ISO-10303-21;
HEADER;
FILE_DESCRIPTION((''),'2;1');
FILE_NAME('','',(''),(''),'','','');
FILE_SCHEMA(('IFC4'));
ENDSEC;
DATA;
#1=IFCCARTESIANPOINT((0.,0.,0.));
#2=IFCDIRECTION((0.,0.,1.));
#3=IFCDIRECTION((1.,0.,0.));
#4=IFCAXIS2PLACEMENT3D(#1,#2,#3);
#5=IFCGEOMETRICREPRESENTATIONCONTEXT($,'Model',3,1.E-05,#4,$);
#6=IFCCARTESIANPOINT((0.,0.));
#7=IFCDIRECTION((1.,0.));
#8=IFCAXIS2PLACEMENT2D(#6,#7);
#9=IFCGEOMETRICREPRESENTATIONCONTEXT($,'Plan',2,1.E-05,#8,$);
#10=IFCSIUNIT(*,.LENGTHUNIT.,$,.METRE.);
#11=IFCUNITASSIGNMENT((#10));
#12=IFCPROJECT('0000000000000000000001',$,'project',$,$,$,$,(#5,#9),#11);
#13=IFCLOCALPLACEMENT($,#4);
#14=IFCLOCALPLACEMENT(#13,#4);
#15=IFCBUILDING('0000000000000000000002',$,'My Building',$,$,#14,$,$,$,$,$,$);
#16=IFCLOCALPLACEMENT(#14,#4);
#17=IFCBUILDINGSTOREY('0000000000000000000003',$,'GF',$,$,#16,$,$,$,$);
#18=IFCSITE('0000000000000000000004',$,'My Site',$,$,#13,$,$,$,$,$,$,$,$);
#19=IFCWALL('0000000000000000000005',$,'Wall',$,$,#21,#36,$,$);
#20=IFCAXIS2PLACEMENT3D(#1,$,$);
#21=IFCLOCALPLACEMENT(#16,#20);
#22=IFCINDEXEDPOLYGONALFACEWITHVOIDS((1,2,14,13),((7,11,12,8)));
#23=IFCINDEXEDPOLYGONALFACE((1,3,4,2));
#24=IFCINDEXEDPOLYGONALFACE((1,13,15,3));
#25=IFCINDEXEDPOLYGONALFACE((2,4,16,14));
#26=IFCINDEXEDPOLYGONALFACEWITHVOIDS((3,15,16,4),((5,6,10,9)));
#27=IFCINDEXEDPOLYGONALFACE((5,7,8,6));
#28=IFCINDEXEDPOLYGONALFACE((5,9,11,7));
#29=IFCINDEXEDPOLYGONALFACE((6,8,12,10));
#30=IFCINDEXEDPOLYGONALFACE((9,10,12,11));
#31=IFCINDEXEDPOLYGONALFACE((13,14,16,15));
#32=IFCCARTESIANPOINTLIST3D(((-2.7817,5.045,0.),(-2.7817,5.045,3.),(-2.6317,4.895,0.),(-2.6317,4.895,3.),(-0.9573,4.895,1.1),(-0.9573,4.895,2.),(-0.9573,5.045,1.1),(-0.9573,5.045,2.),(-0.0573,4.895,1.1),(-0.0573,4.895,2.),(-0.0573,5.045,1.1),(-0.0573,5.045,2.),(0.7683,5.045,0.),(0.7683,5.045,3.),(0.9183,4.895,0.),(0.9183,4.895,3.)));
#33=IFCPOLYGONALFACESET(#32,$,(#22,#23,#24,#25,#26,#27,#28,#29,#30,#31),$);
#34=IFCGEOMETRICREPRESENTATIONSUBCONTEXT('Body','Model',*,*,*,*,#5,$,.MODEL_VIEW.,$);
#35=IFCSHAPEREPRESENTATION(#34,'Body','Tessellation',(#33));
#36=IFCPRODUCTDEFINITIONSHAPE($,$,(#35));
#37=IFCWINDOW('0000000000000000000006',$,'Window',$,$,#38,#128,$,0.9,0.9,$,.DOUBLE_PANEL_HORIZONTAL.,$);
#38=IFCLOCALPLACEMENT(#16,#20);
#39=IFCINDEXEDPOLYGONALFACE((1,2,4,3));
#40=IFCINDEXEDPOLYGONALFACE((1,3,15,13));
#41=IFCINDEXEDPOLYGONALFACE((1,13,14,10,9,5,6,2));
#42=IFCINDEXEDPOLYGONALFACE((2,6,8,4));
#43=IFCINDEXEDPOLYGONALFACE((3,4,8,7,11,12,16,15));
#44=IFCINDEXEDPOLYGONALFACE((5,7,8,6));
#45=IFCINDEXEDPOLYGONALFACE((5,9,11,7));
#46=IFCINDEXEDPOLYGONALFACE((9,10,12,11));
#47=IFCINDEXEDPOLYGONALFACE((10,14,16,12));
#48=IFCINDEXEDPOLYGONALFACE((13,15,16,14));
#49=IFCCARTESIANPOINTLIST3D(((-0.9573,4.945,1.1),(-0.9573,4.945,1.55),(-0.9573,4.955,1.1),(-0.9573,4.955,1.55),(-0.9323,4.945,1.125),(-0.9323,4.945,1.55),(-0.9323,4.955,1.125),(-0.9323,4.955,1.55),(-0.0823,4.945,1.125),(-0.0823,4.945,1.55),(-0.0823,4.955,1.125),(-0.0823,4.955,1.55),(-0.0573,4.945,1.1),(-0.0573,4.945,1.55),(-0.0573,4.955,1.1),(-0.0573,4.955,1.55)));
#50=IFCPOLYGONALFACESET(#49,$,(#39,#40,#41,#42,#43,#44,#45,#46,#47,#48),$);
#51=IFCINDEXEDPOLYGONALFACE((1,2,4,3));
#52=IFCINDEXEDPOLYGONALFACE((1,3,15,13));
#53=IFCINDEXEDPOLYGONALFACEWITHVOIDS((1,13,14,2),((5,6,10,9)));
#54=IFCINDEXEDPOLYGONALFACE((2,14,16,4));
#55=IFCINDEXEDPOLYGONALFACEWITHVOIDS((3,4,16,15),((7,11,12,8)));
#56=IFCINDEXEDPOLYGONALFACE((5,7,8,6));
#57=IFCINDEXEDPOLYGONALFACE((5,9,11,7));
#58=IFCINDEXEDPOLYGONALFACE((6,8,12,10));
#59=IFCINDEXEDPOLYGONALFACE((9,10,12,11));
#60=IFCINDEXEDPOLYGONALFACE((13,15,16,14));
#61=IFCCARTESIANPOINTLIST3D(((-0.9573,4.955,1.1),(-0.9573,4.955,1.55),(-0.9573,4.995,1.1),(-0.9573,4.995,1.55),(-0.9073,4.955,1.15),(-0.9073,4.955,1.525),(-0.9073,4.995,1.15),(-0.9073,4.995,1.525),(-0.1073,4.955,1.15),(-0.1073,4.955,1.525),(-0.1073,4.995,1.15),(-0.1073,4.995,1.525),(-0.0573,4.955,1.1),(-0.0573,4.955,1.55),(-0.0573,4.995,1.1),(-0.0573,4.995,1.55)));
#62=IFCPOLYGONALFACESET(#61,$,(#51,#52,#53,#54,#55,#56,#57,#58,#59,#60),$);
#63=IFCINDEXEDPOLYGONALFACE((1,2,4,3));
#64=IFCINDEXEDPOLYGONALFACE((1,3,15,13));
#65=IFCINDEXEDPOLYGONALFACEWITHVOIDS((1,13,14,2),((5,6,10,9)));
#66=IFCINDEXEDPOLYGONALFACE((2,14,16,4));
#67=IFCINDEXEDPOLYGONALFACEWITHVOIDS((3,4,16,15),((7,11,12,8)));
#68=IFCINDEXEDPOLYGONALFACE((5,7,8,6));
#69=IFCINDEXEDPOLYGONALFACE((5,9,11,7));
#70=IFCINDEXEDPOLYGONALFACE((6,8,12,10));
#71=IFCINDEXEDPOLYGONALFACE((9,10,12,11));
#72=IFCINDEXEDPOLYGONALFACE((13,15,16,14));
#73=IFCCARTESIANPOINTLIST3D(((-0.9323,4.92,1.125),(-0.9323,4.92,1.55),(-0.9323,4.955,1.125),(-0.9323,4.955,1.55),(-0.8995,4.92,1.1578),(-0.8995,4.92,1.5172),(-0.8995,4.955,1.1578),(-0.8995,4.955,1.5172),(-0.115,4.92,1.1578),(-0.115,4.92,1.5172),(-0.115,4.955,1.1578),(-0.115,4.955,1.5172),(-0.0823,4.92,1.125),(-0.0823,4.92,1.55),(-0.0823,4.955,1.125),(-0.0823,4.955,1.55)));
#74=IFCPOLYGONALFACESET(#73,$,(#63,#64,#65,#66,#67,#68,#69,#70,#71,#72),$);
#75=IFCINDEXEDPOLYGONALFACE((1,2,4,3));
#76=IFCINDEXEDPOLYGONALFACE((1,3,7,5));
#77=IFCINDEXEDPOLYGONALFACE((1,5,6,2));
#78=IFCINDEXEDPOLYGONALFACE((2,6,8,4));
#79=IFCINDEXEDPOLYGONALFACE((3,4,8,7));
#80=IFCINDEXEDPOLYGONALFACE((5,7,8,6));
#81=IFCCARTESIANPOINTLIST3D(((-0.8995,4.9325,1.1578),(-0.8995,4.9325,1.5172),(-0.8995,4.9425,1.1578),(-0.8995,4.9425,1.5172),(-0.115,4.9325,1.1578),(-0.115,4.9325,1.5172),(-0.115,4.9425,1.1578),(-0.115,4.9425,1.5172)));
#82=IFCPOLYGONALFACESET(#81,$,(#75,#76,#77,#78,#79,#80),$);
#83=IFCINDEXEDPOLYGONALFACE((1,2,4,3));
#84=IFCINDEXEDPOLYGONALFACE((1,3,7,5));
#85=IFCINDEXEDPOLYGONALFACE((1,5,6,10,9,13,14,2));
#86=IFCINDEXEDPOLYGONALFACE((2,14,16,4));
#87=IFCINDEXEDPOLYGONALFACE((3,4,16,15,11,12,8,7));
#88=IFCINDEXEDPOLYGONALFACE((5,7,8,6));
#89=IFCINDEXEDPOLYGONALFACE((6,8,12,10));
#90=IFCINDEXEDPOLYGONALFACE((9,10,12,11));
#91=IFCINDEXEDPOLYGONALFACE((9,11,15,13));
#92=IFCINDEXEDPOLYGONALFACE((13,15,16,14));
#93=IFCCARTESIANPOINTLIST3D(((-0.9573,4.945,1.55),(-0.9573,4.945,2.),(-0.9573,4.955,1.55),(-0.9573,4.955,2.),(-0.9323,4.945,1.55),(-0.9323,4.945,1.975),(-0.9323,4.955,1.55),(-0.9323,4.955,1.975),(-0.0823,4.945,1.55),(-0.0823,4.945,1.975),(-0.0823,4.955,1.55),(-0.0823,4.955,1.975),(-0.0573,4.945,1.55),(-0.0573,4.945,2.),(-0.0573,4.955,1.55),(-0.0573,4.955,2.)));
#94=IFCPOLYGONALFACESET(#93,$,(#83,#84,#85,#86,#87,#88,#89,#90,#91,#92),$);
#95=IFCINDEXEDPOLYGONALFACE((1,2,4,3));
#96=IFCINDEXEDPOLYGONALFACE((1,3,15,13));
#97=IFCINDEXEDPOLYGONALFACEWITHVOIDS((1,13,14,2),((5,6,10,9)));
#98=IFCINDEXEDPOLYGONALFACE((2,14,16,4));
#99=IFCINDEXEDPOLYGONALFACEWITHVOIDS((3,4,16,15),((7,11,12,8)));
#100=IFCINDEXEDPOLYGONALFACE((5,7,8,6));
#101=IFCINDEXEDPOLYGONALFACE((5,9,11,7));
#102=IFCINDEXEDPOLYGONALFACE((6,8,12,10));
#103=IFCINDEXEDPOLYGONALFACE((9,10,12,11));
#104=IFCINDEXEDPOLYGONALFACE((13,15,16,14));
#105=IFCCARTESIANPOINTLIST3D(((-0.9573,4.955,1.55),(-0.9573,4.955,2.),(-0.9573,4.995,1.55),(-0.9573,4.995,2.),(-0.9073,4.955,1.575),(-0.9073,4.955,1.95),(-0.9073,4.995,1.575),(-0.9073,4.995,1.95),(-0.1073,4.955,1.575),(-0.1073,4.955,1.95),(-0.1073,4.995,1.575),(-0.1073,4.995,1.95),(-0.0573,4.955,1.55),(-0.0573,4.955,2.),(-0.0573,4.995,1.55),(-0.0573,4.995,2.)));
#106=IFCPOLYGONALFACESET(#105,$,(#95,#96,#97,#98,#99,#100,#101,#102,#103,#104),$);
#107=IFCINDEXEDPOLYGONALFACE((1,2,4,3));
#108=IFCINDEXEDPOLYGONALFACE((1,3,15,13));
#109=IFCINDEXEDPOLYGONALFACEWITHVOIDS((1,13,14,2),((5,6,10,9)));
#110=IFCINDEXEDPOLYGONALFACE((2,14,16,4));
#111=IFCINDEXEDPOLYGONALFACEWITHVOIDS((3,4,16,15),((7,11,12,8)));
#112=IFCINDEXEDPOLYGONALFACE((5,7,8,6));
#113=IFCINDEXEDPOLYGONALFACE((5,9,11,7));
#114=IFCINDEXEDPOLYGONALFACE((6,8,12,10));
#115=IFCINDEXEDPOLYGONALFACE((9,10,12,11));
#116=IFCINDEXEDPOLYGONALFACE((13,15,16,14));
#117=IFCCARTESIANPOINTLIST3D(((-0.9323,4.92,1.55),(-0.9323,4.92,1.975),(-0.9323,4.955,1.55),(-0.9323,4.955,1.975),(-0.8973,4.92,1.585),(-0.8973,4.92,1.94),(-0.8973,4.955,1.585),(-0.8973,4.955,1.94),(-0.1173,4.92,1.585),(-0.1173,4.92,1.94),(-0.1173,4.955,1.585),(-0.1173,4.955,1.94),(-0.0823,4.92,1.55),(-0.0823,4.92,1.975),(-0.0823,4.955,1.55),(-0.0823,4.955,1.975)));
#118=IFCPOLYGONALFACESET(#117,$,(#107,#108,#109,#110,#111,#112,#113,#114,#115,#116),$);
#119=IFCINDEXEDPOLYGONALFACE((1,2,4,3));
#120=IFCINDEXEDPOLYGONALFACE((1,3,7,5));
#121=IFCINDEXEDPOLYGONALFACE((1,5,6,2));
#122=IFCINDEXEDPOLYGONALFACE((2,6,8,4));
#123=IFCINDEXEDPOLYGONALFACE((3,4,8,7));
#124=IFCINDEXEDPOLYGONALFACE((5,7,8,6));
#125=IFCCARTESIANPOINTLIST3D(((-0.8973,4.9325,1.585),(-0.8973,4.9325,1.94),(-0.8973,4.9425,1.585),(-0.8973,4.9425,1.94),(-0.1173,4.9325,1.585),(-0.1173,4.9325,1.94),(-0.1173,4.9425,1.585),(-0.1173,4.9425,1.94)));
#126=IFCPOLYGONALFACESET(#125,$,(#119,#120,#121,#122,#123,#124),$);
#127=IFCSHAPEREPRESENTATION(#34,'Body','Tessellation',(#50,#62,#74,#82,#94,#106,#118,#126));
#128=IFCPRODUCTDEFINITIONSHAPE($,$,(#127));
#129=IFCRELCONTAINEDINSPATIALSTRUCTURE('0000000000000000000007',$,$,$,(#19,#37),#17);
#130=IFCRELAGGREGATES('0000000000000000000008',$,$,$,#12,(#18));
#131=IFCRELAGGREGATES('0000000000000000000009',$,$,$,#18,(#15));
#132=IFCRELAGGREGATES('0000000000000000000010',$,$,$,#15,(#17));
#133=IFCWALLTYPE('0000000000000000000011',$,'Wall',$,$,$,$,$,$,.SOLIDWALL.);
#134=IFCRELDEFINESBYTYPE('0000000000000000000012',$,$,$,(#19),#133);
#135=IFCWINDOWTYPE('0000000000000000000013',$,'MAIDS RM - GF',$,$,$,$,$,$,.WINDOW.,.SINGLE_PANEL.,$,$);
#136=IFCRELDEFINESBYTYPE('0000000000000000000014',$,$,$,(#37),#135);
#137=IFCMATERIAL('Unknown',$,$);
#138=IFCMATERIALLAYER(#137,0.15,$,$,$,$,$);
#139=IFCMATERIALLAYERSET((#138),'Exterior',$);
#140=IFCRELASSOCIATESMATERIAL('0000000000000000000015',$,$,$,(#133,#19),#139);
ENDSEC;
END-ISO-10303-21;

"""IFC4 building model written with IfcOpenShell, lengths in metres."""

from ifc_helpers import new_model, entity, si_unit, frame, origin_with_axes, origin_2d_with_axis, place, context, subcontext, project, spatial, line, indexed_curve, outline, extrude, shape, source, transform, mapped, material, layer, layer_set, layer_usage, type_object, type_shapes, element, fill, save


model = new_model("IFC4")

# Units and contexts
model_context = context("Model", 3, precision=1e-05, world=origin_with_axes())
plan_context = context("Plan", 2, precision=1e-05, world=origin_2d_with_axis())
body_context_1 = subcontext(model_context, "Body", "Model", "MODEL_VIEW")
body_context_2 = subcontext(plan_context, "Body", "Plan", "PLAN_VIEW")
ifc_project = project(units=[si_unit("LENGTHUNIT", "METRE")], contexts=[model_context, plan_context])

# Site, building, storey
site_placement = place(None, origin_with_axes())
site = spatial("IfcSite", under=ifc_project, at=site_placement, Name="My Site")
building_placement = place(site_placement, origin_with_axes())
building = spatial("IfcBuilding", under=site, at=building_placement, Name="My Building")
storey_placement = place(building_placement, origin_with_axes())
storey = spatial("IfcBuildingStorey", under=building, at=storey_placement, Name="GF")

# Shared definitions
ifc_material = material(Name="Unknown")
ifc_layer_1 = layer(ifc_material, 0.15)
ifc_layer_set_1 = layer_set([ifc_layer_1], Name="Exterior")
wall_type_1 = type_object("IfcWallType", Name="Wall", PredefinedType="SOLIDWALL", material=ifc_layer_set_1)

# Wall, opening, window
ifc_layer_usage_1 = layer_usage(ifc_layer_set_1, "AXIS2", "POSITIVE", 0.0)
wall_1_placement = place(storey_placement, frame((0.7683, 5.045, 0.0), z_axis=(0.0, 0.0, 1.0), x_axis=(-1.0, 0.0, 0.0)))
wall_1 = element("IfcWall", 1, at=wall_1_placement, inside=storey, type_object=wall_type_1, material=ifc_layer_usage_1, Name="Wall", context=body_context_1, shape_type="SweptSolid", body=[
    extrude(outline(indexed_curve([(0.0, 0.0), (-0.15, 0.15), (3.4, 0.15), (3.55, 0.0)], segments=[line(1, 2, 3, 4, 1)])), origin_with_axes(), (0.0, 0.0, 1.0), 3.0),
])
shared_shape_1 = source(origin_with_axes(), body_context_1, "Body", "SweptSolid", [
    extrude(outline(indexed_curve([(0.0, 0.0), (0.9, 0.0), (0.9, 0.9), (0.0, 0.9)], segments=[line(1, 2, 3, 4, 1)])), frame((0.0, -0.6, 0.0), z_axis=(0.0, -1.0, 0.0), x_axis=(1.0, 0.0, 0.0)), (0.0, 0.0, -1.0), 1.2),
])
opening_1_placement = place(wall_1_placement, frame((0.8256, 0.0, 1.1), z_axis=(0.0, 0.0, 1.0), x_axis=(1.0, 0.0, 0.0)))
opening_1 = element("IfcOpeningElement", 2, at=opening_1_placement, cuts=wall_1, PredefinedType="OPENING", context=body_context_1, shape_type="MappedRepresentation", body=[
    mapped(shared_shape_1, transform((0.0, 0.0, 0.0), x_axis=(1.0, 0.0, 0.0), y_axis=(0.0, 1.0, 0.0), z_axis=(0.0, 0.0, 1.0), scale=1.0)),
])
window_type_1 = type_object("IfcWindowType", Name="MAIDS RM - GF", PartitioningType="SINGLE_PANEL", PredefinedType="WINDOW")
shared_shape_2 = source(origin_with_axes(), body_context_1, "Body", "SweptSolid", [
    extrude(outline(indexed_curve([(0.9, 0.45), (0.9, 0.0), (0.0, 0.0), (0.0, 0.45), (0.025, 0.45), (0.025, 0.025), (0.875, 0.025), (0.875, 0.45)], segments=[line(1, 2, 3, 4, 5, 6, 7, 8, 1)])), frame((0.0, 0.09, 0.0), z_axis=(0.0, -1.0, 0.0), x_axis=(1.0, 0.0, 0.0)), (0.0, 0.0, -1.0), 0.01),
    extrude(outline(indexed_curve([(0.0, 0.0), (0.9, 0.0), (0.9, 0.45), (0.0, 0.45)], segments=[line(1, 2, 3, 4, 1)]), holes=[indexed_curve([(0.05, 0.05), (0.85, 0.05), (0.85, 0.425), (0.05, 0.425)], segments=[line(1, 2, 3, 4, 1)])]), frame((0.0, 0.05, 0.0), z_axis=(0.0, -1.0, 0.0), x_axis=(1.0, 0.0, 0.0)), (0.0, 0.0, -1.0), 0.04),
    extrude(outline(indexed_curve([(0.0, 0.0), (0.85, 0.0), (0.85, 0.425), (0.0, 0.425)], segments=[line(1, 2, 3, 4, 1)]), holes=[indexed_curve([(0.0328, 0.0328), (0.8172, 0.0328), (0.8172, 0.3922), (0.0328, 0.3922)], segments=[line(1, 2, 3, 4, 1)])]), frame((0.025, 0.09, 0.025), z_axis=(0.0, -1.0, 0.0), x_axis=(1.0, 0.0, 0.0)), (0.0, 0.0, -1.0), 0.035),
    extrude(outline(indexed_curve([(0.0328, 0.0328), (0.8172, 0.0328), (0.8172, 0.3922), (0.0328, 0.3922)], segments=[line(1, 2, 3, 4, 1)])), frame((0.025, 0.1025, 0.025), z_axis=(0.0, -1.0, 0.0), x_axis=(1.0, 0.0, 0.0)), (0.0, 0.0, -1.0), 0.01),
    extrude(outline(indexed_curve([(0.0, 0.0), (0.0, 0.45), (0.9, 0.45), (0.9, 0.0), (0.875, 0.0), (0.875, 0.425), (0.025, 0.425), (0.025, 0.0)], segments=[line(1, 2, 3, 4, 5, 6, 7, 8, 1)])), frame((0.0, 0.09, 0.45), z_axis=(0.0, -1.0, 0.0), x_axis=(1.0, 0.0, 0.0)), (0.0, 0.0, -1.0), 0.01),
    extrude(outline(indexed_curve([(0.0, 0.0), (0.9, 0.0), (0.9, 0.45), (0.0, 0.45)], segments=[line(1, 2, 3, 4, 1)]), holes=[indexed_curve([(0.05, 0.025), (0.85, 0.025), (0.85, 0.4), (0.05, 0.4)], segments=[line(1, 2, 3, 4, 1)])]), frame((0.0, 0.05, 0.45), z_axis=(0.0, -1.0, 0.0), x_axis=(1.0, 0.0, 0.0)), (0.0, 0.0, -1.0), 0.04),
    extrude(outline(indexed_curve([(0.0, 0.0), (0.85, 0.0), (0.85, 0.425), (0.0, 0.425)], segments=[line(1, 2, 3, 4, 1)]), holes=[indexed_curve([(0.035, 0.035), (0.815, 0.035), (0.815, 0.39), (0.035, 0.39)], segments=[line(1, 2, 3, 4, 1)])]), frame((0.025, 0.09, 0.45), z_axis=(0.0, -1.0, 0.0), x_axis=(1.0, 0.0, 0.0)), (0.0, 0.0, -1.0), 0.035),
    extrude(outline(indexed_curve([(0.035, 0.035), (0.815, 0.035), (0.815, 0.39), (0.035, 0.39)], segments=[line(1, 2, 3, 4, 1)])), frame((0.025, 0.1025, 0.45), z_axis=(0.0, -1.0, 0.0), x_axis=(1.0, 0.0, 0.0)), (0.0, 0.0, -1.0), 0.01),
])
shared_shape_3 = source(origin_with_axes(), body_context_2, "Body", "Curve2D", [
    entity("IfcIndexedPolyCurve", entity("IfcCartesianPointList2D", [[0.05, 0.05], [0.85, 0.05]])),
    entity("IfcIndexedPolyCurve", entity("IfcCartesianPointList2D", [[0.0, 0.1], [0.025, 0.1], [0.025, 0.09], [0.05, 0.09], [0.05, 0.05], [0.0, 0.05]]), [entity("IfcLineIndex", [1, 2, 3, 4, 5, 6, 1])]),
    entity("IfcIndexedPolyCurve", entity("IfcCartesianPointList2D", [[0.9, 0.1], [0.875, 0.1], [0.875, 0.09], [0.85, 0.09], [0.85, 0.05], [0.9, 0.05]]), [entity("IfcLineIndex", [1, 2, 3, 4, 5, 6, 1])]),
    entity("IfcIndexedPolyCurve", entity("IfcCartesianPointList2D", [[0.025, 0.09], [0.06, 0.09], [0.06, 0.125], [0.025, 0.125]]), [entity("IfcLineIndex", [1, 2, 3, 4, 1])]),
    entity("IfcIndexedPolyCurve", entity("IfcCartesianPointList2D", [[0.875, 0.09], [0.84, 0.09], [0.84, 0.125], [0.875, 0.125]]), [entity("IfcLineIndex", [1, 2, 3, 4, 1])]),
    entity("IfcIndexedPolyCurve", entity("IfcCartesianPointList2D", [[0.06, 0.09], [0.84, 0.09]])),
    entity("IfcIndexedPolyCurve", entity("IfcCartesianPointList2D", [[0.06, 0.125], [0.84, 0.125]])),
    entity("IfcIndexedPolyCurve", entity("IfcCartesianPointList2D", [[0.06, 0.1075], [0.84, 0.1075]])),
])
type_shapes(window_type_1, [shared_shape_2, shared_shape_3])
window_1_placement = place(opening_1_placement, frame((0.0, 0.0, 0.0), z_axis=(0.0, 0.0, 1.0), x_axis=(1.0, 0.0, 0.0)))
window_1 = element("IfcWindow", 3, at=window_1_placement, inside=storey, type_object=window_type_1, Name="Window", OverallHeight=0.9, OverallWidth=0.9, PartitioningType="DOUBLE_PANEL_HORIZONTAL", shapes=[
    shape(body_context_1, "Body", "MappedRepresentation", [mapped(shared_shape_2, transform((0.0, 0.0, 0.0), x_axis=(1.0, 0.0, 0.0), y_axis=(0.0, 1.0, 0.0), z_axis=(0.0, 0.0, 1.0), scale=1.0))]),
    shape(body_context_2, "Body", "MappedRepresentation", [mapped(shared_shape_3, transform((0.0, 0.0, 0.0), x_axis=(1.0, 0.0, 0.0), y_axis=(0.0, 1.0, 0.0), z_axis=(0.0, 0.0, 1.0), scale=1.0))]),
])
fill(opening_1, window_1)

save(model, "model.ifc")
